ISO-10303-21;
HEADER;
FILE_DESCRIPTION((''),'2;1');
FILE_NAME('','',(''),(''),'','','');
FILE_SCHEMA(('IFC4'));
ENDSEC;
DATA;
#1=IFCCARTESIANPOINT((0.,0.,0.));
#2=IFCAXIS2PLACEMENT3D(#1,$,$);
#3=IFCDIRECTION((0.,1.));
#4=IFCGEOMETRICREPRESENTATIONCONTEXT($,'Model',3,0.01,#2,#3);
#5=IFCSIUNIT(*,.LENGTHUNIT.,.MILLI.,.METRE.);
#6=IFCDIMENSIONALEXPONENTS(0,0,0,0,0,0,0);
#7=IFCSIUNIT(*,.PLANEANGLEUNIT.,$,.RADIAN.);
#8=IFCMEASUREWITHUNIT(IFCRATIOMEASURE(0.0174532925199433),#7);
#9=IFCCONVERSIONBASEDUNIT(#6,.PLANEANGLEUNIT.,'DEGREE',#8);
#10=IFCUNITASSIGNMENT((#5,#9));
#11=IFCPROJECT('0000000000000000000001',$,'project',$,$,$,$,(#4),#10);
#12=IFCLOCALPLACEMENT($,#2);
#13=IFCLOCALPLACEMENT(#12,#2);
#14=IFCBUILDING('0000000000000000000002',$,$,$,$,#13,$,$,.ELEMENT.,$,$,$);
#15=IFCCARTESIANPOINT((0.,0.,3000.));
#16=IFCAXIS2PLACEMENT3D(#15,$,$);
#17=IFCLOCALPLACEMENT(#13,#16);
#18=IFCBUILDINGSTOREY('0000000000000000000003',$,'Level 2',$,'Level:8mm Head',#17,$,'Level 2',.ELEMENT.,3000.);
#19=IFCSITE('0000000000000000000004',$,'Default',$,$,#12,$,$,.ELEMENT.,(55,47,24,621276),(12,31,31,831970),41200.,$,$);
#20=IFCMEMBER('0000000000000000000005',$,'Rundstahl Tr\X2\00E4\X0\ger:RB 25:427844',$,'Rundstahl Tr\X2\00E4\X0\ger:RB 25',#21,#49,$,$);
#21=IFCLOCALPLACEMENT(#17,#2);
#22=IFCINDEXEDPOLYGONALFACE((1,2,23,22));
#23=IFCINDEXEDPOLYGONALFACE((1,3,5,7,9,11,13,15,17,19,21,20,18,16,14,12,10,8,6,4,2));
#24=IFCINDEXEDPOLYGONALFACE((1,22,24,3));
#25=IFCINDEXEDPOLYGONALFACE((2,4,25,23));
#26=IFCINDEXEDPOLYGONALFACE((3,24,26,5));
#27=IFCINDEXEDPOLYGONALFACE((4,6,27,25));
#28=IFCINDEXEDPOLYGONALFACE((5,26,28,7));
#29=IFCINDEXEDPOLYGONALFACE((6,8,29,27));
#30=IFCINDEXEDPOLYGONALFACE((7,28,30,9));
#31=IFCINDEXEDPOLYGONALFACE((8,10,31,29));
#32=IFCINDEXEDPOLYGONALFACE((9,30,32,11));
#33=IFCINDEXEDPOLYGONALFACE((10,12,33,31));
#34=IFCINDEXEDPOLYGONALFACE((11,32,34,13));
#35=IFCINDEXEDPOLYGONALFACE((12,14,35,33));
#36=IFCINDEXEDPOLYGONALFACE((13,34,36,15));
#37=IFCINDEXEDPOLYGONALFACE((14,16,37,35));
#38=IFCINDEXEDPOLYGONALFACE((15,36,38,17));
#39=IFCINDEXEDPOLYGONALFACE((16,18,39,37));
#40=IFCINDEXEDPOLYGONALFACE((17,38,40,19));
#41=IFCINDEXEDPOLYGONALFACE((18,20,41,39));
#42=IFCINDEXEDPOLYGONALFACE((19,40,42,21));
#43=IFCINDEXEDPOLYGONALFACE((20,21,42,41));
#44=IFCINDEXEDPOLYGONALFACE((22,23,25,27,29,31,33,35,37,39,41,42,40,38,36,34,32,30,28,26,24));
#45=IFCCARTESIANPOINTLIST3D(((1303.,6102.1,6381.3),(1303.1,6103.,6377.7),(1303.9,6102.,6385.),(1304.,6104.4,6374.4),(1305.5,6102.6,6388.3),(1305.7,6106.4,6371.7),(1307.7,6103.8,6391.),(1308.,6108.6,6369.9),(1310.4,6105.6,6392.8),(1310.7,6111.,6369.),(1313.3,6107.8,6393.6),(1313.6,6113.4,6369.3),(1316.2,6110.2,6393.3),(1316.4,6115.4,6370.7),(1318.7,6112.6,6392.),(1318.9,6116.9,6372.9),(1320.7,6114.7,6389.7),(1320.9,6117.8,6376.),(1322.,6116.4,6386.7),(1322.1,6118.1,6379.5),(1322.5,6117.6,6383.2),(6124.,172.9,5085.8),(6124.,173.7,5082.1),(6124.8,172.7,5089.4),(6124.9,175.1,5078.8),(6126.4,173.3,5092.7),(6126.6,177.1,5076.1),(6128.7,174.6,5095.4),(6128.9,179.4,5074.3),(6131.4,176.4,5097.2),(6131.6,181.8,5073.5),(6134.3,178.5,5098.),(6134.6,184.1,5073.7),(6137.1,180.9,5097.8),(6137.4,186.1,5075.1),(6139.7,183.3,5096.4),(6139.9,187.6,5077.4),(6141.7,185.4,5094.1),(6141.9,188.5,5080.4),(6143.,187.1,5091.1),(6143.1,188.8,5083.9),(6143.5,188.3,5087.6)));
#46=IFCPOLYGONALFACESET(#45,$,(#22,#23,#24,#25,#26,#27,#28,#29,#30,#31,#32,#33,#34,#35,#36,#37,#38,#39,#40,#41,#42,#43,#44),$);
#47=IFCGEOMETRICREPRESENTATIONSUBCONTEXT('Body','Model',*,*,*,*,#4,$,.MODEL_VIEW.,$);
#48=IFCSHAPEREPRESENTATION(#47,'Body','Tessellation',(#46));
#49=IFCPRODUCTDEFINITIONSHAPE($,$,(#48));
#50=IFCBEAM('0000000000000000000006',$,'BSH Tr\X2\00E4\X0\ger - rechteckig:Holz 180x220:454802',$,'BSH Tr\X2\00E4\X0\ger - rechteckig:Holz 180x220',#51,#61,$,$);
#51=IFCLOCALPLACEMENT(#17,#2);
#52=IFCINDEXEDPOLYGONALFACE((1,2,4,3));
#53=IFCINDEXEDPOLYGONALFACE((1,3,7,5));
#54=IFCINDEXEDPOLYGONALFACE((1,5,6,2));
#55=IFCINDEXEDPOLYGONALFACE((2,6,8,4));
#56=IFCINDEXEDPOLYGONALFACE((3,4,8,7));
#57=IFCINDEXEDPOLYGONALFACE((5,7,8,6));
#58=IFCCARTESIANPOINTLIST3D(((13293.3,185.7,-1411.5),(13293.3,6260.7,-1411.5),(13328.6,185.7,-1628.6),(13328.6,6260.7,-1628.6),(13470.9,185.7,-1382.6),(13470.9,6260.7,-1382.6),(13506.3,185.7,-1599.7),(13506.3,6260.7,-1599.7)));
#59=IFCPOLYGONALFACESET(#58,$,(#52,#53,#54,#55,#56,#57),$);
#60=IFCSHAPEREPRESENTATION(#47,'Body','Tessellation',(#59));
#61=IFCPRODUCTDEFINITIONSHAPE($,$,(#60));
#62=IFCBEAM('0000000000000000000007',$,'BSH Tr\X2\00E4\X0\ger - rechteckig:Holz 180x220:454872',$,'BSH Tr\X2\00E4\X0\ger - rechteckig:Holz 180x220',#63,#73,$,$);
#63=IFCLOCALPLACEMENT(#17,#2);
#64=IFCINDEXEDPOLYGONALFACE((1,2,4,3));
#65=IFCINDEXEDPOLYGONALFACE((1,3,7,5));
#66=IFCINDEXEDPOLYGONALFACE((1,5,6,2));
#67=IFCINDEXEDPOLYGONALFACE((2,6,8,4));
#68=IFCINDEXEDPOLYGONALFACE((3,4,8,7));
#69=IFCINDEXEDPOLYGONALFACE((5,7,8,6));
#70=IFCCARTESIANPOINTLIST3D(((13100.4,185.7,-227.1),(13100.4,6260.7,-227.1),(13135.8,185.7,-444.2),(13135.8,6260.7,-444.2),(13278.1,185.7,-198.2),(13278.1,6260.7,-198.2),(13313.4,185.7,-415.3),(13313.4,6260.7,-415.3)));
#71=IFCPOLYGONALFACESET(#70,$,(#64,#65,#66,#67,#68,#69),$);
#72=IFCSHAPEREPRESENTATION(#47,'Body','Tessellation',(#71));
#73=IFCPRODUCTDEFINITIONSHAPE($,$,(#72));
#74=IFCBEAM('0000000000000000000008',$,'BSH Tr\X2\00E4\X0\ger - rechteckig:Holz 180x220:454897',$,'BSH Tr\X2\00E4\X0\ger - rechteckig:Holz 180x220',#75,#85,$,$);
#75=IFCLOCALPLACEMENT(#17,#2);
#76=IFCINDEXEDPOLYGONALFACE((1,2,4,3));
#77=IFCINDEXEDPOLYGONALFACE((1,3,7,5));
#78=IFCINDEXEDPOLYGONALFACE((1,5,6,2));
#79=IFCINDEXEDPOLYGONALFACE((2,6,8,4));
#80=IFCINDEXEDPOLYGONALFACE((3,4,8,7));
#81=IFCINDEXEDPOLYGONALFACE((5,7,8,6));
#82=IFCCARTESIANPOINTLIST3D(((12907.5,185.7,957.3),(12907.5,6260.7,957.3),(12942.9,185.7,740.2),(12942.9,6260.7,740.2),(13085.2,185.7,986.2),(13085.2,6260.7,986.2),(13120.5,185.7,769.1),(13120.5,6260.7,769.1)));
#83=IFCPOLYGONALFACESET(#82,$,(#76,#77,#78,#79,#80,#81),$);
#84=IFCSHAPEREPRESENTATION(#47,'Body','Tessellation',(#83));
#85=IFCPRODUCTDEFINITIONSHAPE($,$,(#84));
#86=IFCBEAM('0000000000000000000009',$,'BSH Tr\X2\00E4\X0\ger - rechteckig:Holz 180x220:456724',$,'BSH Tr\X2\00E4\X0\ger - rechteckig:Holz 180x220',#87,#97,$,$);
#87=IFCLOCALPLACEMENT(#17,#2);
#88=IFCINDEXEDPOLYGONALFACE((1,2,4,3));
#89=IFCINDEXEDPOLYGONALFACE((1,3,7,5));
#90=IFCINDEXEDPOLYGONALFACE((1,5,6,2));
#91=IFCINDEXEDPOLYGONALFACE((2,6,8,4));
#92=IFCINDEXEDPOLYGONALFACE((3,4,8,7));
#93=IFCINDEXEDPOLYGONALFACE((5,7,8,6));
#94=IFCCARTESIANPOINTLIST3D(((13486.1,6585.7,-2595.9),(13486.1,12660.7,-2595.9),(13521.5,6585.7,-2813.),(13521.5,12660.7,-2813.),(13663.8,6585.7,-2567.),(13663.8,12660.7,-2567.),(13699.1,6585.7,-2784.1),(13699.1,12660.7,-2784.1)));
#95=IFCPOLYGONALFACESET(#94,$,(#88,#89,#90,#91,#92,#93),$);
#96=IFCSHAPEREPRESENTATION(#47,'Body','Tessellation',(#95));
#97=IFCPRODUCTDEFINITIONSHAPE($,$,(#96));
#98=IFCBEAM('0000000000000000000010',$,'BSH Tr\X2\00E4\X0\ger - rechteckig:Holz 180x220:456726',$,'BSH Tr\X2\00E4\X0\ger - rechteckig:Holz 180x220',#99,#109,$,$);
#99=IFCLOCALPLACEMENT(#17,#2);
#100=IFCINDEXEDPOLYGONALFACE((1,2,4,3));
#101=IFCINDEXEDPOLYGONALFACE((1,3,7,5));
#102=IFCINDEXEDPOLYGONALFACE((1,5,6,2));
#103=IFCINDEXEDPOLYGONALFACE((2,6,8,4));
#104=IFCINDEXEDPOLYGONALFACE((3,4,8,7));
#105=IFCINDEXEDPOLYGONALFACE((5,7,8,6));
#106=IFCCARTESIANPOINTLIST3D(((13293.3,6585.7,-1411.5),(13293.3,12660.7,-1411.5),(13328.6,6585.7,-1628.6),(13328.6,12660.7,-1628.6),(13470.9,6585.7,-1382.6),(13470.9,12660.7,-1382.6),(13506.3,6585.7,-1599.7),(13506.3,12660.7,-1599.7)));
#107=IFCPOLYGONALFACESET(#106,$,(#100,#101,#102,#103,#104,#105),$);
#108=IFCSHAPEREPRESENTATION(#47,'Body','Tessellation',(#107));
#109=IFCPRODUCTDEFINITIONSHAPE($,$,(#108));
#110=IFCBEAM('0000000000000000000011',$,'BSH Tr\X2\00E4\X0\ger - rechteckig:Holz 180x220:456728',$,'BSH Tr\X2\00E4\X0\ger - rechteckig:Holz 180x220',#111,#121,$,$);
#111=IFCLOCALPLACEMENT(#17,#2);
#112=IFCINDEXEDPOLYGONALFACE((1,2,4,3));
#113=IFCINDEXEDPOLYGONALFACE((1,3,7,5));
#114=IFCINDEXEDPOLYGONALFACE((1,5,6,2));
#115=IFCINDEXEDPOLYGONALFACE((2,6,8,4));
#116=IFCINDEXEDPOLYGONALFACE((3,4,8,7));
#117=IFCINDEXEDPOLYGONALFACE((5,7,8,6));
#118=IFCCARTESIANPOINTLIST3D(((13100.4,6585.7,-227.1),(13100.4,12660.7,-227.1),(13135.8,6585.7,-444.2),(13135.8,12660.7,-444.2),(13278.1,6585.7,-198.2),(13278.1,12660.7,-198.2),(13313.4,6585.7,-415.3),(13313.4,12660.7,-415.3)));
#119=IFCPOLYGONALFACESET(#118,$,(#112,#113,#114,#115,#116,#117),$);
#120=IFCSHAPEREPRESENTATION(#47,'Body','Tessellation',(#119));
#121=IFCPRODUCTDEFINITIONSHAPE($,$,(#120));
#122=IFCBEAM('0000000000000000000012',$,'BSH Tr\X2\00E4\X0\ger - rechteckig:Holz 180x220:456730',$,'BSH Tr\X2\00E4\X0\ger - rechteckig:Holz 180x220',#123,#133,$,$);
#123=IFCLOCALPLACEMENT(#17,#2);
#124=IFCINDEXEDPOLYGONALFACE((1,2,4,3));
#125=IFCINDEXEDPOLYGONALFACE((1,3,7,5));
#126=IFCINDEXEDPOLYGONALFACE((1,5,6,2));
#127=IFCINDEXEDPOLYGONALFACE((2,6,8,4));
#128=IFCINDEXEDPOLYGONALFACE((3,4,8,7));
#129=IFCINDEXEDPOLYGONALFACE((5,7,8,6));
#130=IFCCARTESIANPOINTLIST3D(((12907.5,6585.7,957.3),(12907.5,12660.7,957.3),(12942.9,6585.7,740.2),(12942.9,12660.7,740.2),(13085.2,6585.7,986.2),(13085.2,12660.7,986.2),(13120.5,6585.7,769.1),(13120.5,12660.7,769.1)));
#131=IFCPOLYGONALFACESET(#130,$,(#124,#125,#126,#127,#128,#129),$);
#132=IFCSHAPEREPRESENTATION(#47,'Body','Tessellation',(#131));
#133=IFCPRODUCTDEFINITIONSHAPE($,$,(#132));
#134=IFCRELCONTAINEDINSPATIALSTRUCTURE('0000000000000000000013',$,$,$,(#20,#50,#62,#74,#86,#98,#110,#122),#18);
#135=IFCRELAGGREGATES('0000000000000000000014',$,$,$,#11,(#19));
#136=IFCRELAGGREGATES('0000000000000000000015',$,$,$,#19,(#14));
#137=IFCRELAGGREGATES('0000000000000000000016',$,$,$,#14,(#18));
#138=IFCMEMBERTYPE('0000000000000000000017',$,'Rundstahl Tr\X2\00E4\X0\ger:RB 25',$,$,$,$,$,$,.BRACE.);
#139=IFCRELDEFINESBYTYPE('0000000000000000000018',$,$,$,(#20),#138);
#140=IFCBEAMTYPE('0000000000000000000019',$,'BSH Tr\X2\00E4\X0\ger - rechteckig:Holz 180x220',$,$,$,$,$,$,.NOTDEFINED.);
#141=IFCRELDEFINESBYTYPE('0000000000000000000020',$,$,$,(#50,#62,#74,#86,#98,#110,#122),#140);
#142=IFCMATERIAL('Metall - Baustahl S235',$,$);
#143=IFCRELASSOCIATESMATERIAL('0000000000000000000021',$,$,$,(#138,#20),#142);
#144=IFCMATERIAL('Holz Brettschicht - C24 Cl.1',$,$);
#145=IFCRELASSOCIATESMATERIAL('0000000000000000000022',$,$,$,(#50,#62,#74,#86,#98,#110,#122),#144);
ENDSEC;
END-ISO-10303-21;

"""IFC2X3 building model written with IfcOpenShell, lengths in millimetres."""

from ifc_helpers import new_model, entity, si_unit, converted_unit, direction, frame, frame_2d, origin, place, context, subcontext, project, spatial, rectangle, circle, extrude, source, transform, mapped, material, type_object, type_shapes, element, save


model = new_model("IFC2X3")

# Units and contexts
model_context = context("Model", 3, precision=0.01, world=origin(), true_north=direction((0.0, 1.0)))
body_context = subcontext(model_context, "Body", "Model", "MODEL_VIEW")
ifc_project = project(units=[si_unit("LENGTHUNIT", "METRE", prefix="MILLI"), converted_unit("PLANEANGLEUNIT", "DEGREE", entity("IfcRatioMeasure", 0.0174532925199433), si_unit("PLANEANGLEUNIT", "RADIAN"), dimensions=[0, 0, 0, 0, 0, 0, 0])], contexts=[model_context])

# Site, building, storey
site_placement = place(None, origin())
site = spatial("IfcSite", under=ifc_project, at=site_placement, Name="Default", CompositionType="ELEMENT", RefLatitude=(55, 47, 24, 621276), RefLongitude=(12, 31, 31, 831970), RefElevation=41200.0)
building_placement = place(site_placement, origin())
building = spatial("IfcBuilding", under=site, at=building_placement, CompositionType="ELEMENT")
storey_placement = place(building_placement, frame((0.0, 0.0, 3000.0)))
storey = spatial("IfcBuildingStorey", under=building, at=storey_placement, Name="Level 2", ObjectType="Level:8mm Head", LongName="Level 2", CompositionType="ELEMENT", Elevation=3000.0)

# Member
ifc_material_1 = material(Name="Metall - Baustahl S235")
member_type_1 = type_object("IfcMemberType", Name="Rundstahl Träger:RB 25", PredefinedType="BRACE", material=ifc_material_1)
shared_shape_1 = source(origin(), body_context, "Body", "SweptSolid", [
    extrude(circle(Radius=12.5, at=frame_2d((0.0, 0.0), x_axis=(1.0, 0.0))), frame((-3875.1, 0.0, 0.0), z_axis=(1.0, 0.0, 0.0), x_axis=(0.0, -1.0, 0.0)), (0.0, 0.0, 1.0), 7750.9),
])
type_shapes(member_type_1, [shared_shape_1])
member_1_placement = place(storey_placement, frame((3723.0, 3145.6, 5733.6), z_axis=(0.105449, -0.129691, 0.985931), x_axis=(0.621987, -0.764979, -0.167151)))
element("IfcMember", 1, at=member_1_placement, inside=storey, type_object=member_type_1, material=ifc_material_1, Name="Rundstahl Träger:RB 25:427844", ObjectType="Rundstahl Träger:RB 25", context=body_context, shape_type="MappedRepresentation", body=[
    mapped(shared_shape_1, transform((0.0, 0.0, 0.0), scale=1.0)),
])

# Beams
ifc_material_2 = material(Name="Holz Brettschicht - C24 Cl.1")
beam_type_1 = type_object("IfcBeamType", Name="BSH Träger - rechteckig:Holz 180x220", PredefinedType="NOTDEFINED")
beam_1_placement = place(storey_placement, frame((13488.6, 923.2, -1491.1), z_axis=(0.0, 0.0, 1.0), x_axis=(0.0, 1.0, 0.0)))
element("IfcBeam", 2, at=beam_1_placement, inside=storey, type_object=beam_type_1, material=ifc_material_2, Name="BSH Träger - rechteckig:Holz 180x220:454802", ObjectType="BSH Träger - rechteckig:Holz 180x220", context=body_context, shape_type="SweptSolid", body=[
    extrude(rectangle(XDim=220.0, YDim=180.0, at=frame_2d((0.0, 0.0), x_axis=(1.0, 0.0))), frame((-737.5, 88.8, -14.5), z_axis=(1.0, 0.0, 0.0), x_axis=(0.0, 0.160724, 0.986999)), (0.0, 0.0, 1.0), 6075.0),
])
beam_2_placement = place(storey_placement, frame((13295.7, 923.2, -306.7), z_axis=(0.0, 0.0, 1.0), x_axis=(0.0, 1.0, 0.0)))
element("IfcBeam", 3, at=beam_2_placement, inside=storey, type_object=beam_type_1, material=ifc_material_2, Name="BSH Träger - rechteckig:Holz 180x220:454872", ObjectType="BSH Träger - rechteckig:Holz 180x220", context=body_context, shape_type="SweptSolid", body=[
    extrude(rectangle(XDim=220.0, YDim=180.0, at=frame_2d((0.0, 0.0), x_axis=(1.0, 0.0))), frame((-737.5, 88.8, -14.5), z_axis=(1.0, 0.0, 0.0), x_axis=(0.0, 0.160724, 0.986999)), (0.0, 0.0, 1.0), 6075.0),
])
beam_3_placement = place(storey_placement, frame((13102.9, 923.2, 877.7), z_axis=(0.0, 0.0, 1.0), x_axis=(0.0, 1.0, 0.0)))
element("IfcBeam", 4, at=beam_3_placement, inside=storey, type_object=beam_type_1, material=ifc_material_2, Name="BSH Träger - rechteckig:Holz 180x220:454897", ObjectType="BSH Träger - rechteckig:Holz 180x220", context=body_context, shape_type="SweptSolid", body=[
    extrude(rectangle(XDim=220.0, YDim=180.0, at=frame_2d((0.0, 0.0), x_axis=(1.0, 0.0))), frame((-737.5, 88.8, -14.5), z_axis=(1.0, 0.0, 0.0), x_axis=(0.0, 0.160724, 0.986999)), (0.0, 0.0, 1.0), 6075.0),
])
beam_4_placement = place(storey_placement, frame((13681.5, 7323.2, -2675.5), z_axis=(0.0, 0.0, 1.0), x_axis=(0.0, 1.0, 0.0)))
element("IfcBeam", 5, at=beam_4_placement, inside=storey, type_object=beam_type_1, material=ifc_material_2, Name="BSH Träger - rechteckig:Holz 180x220:456724", ObjectType="BSH Träger - rechteckig:Holz 180x220", context=body_context, shape_type="SweptSolid", body=[
    extrude(rectangle(XDim=220.0, YDim=180.0, at=frame_2d((0.0, 0.0), x_axis=(1.0, 0.0))), frame((-737.5, 88.8, -14.5), z_axis=(1.0, 0.0, 0.0), x_axis=(0.0, 0.160724, 0.986999)), (0.0, 0.0, 1.0), 6075.0),
])
beam_5_placement = place(storey_placement, frame((13488.6, 7323.2, -1491.1), z_axis=(0.0, 0.0, 1.0), x_axis=(0.0, 1.0, 0.0)))
element("IfcBeam", 6, at=beam_5_placement, inside=storey, type_object=beam_type_1, material=ifc_material_2, Name="BSH Träger - rechteckig:Holz 180x220:456726", ObjectType="BSH Träger - rechteckig:Holz 180x220", context=body_context, shape_type="SweptSolid", body=[
    extrude(rectangle(XDim=220.0, YDim=180.0, at=frame_2d((0.0, 0.0), x_axis=(1.0, 0.0))), frame((-737.5, 88.8, -14.5), z_axis=(1.0, 0.0, 0.0), x_axis=(0.0, 0.160724, 0.986999)), (0.0, 0.0, 1.0), 6075.0),
])
beam_6_placement = place(storey_placement, frame((13295.7, 7323.2, -306.7), z_axis=(0.0, 0.0, 1.0), x_axis=(0.0, 1.0, 0.0)))
element("IfcBeam", 7, at=beam_6_placement, inside=storey, type_object=beam_type_1, material=ifc_material_2, Name="BSH Träger - rechteckig:Holz 180x220:456728", ObjectType="BSH Träger - rechteckig:Holz 180x220", context=body_context, shape_type="SweptSolid", body=[
    extrude(rectangle(XDim=220.0, YDim=180.0, at=frame_2d((0.0, 0.0), x_axis=(1.0, 0.0))), frame((-737.5, 88.8, -14.5), z_axis=(1.0, 0.0, 0.0), x_axis=(0.0, 0.160724, 0.986999)), (0.0, 0.0, 1.0), 6075.0),
])
beam_7_placement = place(storey_placement, frame((13102.9, 7323.2, 877.7), z_axis=(0.0, 0.0, 1.0), x_axis=(0.0, 1.0, 0.0)))
element("IfcBeam", 8, at=beam_7_placement, inside=storey, type_object=beam_type_1, material=ifc_material_2, Name="BSH Träger - rechteckig:Holz 180x220:456730", ObjectType="BSH Träger - rechteckig:Holz 180x220", context=body_context, shape_type="SweptSolid", body=[
    extrude(rectangle(XDim=220.0, YDim=180.0, at=frame_2d((0.0, 0.0), x_axis=(1.0, 0.0))), frame((-737.5, 88.8, -14.5), z_axis=(1.0, 0.0, 0.0), x_axis=(0.0, 0.160724, 0.986999)), (0.0, 0.0, 1.0), 6075.0),
])

save(model, "model.ifc")
